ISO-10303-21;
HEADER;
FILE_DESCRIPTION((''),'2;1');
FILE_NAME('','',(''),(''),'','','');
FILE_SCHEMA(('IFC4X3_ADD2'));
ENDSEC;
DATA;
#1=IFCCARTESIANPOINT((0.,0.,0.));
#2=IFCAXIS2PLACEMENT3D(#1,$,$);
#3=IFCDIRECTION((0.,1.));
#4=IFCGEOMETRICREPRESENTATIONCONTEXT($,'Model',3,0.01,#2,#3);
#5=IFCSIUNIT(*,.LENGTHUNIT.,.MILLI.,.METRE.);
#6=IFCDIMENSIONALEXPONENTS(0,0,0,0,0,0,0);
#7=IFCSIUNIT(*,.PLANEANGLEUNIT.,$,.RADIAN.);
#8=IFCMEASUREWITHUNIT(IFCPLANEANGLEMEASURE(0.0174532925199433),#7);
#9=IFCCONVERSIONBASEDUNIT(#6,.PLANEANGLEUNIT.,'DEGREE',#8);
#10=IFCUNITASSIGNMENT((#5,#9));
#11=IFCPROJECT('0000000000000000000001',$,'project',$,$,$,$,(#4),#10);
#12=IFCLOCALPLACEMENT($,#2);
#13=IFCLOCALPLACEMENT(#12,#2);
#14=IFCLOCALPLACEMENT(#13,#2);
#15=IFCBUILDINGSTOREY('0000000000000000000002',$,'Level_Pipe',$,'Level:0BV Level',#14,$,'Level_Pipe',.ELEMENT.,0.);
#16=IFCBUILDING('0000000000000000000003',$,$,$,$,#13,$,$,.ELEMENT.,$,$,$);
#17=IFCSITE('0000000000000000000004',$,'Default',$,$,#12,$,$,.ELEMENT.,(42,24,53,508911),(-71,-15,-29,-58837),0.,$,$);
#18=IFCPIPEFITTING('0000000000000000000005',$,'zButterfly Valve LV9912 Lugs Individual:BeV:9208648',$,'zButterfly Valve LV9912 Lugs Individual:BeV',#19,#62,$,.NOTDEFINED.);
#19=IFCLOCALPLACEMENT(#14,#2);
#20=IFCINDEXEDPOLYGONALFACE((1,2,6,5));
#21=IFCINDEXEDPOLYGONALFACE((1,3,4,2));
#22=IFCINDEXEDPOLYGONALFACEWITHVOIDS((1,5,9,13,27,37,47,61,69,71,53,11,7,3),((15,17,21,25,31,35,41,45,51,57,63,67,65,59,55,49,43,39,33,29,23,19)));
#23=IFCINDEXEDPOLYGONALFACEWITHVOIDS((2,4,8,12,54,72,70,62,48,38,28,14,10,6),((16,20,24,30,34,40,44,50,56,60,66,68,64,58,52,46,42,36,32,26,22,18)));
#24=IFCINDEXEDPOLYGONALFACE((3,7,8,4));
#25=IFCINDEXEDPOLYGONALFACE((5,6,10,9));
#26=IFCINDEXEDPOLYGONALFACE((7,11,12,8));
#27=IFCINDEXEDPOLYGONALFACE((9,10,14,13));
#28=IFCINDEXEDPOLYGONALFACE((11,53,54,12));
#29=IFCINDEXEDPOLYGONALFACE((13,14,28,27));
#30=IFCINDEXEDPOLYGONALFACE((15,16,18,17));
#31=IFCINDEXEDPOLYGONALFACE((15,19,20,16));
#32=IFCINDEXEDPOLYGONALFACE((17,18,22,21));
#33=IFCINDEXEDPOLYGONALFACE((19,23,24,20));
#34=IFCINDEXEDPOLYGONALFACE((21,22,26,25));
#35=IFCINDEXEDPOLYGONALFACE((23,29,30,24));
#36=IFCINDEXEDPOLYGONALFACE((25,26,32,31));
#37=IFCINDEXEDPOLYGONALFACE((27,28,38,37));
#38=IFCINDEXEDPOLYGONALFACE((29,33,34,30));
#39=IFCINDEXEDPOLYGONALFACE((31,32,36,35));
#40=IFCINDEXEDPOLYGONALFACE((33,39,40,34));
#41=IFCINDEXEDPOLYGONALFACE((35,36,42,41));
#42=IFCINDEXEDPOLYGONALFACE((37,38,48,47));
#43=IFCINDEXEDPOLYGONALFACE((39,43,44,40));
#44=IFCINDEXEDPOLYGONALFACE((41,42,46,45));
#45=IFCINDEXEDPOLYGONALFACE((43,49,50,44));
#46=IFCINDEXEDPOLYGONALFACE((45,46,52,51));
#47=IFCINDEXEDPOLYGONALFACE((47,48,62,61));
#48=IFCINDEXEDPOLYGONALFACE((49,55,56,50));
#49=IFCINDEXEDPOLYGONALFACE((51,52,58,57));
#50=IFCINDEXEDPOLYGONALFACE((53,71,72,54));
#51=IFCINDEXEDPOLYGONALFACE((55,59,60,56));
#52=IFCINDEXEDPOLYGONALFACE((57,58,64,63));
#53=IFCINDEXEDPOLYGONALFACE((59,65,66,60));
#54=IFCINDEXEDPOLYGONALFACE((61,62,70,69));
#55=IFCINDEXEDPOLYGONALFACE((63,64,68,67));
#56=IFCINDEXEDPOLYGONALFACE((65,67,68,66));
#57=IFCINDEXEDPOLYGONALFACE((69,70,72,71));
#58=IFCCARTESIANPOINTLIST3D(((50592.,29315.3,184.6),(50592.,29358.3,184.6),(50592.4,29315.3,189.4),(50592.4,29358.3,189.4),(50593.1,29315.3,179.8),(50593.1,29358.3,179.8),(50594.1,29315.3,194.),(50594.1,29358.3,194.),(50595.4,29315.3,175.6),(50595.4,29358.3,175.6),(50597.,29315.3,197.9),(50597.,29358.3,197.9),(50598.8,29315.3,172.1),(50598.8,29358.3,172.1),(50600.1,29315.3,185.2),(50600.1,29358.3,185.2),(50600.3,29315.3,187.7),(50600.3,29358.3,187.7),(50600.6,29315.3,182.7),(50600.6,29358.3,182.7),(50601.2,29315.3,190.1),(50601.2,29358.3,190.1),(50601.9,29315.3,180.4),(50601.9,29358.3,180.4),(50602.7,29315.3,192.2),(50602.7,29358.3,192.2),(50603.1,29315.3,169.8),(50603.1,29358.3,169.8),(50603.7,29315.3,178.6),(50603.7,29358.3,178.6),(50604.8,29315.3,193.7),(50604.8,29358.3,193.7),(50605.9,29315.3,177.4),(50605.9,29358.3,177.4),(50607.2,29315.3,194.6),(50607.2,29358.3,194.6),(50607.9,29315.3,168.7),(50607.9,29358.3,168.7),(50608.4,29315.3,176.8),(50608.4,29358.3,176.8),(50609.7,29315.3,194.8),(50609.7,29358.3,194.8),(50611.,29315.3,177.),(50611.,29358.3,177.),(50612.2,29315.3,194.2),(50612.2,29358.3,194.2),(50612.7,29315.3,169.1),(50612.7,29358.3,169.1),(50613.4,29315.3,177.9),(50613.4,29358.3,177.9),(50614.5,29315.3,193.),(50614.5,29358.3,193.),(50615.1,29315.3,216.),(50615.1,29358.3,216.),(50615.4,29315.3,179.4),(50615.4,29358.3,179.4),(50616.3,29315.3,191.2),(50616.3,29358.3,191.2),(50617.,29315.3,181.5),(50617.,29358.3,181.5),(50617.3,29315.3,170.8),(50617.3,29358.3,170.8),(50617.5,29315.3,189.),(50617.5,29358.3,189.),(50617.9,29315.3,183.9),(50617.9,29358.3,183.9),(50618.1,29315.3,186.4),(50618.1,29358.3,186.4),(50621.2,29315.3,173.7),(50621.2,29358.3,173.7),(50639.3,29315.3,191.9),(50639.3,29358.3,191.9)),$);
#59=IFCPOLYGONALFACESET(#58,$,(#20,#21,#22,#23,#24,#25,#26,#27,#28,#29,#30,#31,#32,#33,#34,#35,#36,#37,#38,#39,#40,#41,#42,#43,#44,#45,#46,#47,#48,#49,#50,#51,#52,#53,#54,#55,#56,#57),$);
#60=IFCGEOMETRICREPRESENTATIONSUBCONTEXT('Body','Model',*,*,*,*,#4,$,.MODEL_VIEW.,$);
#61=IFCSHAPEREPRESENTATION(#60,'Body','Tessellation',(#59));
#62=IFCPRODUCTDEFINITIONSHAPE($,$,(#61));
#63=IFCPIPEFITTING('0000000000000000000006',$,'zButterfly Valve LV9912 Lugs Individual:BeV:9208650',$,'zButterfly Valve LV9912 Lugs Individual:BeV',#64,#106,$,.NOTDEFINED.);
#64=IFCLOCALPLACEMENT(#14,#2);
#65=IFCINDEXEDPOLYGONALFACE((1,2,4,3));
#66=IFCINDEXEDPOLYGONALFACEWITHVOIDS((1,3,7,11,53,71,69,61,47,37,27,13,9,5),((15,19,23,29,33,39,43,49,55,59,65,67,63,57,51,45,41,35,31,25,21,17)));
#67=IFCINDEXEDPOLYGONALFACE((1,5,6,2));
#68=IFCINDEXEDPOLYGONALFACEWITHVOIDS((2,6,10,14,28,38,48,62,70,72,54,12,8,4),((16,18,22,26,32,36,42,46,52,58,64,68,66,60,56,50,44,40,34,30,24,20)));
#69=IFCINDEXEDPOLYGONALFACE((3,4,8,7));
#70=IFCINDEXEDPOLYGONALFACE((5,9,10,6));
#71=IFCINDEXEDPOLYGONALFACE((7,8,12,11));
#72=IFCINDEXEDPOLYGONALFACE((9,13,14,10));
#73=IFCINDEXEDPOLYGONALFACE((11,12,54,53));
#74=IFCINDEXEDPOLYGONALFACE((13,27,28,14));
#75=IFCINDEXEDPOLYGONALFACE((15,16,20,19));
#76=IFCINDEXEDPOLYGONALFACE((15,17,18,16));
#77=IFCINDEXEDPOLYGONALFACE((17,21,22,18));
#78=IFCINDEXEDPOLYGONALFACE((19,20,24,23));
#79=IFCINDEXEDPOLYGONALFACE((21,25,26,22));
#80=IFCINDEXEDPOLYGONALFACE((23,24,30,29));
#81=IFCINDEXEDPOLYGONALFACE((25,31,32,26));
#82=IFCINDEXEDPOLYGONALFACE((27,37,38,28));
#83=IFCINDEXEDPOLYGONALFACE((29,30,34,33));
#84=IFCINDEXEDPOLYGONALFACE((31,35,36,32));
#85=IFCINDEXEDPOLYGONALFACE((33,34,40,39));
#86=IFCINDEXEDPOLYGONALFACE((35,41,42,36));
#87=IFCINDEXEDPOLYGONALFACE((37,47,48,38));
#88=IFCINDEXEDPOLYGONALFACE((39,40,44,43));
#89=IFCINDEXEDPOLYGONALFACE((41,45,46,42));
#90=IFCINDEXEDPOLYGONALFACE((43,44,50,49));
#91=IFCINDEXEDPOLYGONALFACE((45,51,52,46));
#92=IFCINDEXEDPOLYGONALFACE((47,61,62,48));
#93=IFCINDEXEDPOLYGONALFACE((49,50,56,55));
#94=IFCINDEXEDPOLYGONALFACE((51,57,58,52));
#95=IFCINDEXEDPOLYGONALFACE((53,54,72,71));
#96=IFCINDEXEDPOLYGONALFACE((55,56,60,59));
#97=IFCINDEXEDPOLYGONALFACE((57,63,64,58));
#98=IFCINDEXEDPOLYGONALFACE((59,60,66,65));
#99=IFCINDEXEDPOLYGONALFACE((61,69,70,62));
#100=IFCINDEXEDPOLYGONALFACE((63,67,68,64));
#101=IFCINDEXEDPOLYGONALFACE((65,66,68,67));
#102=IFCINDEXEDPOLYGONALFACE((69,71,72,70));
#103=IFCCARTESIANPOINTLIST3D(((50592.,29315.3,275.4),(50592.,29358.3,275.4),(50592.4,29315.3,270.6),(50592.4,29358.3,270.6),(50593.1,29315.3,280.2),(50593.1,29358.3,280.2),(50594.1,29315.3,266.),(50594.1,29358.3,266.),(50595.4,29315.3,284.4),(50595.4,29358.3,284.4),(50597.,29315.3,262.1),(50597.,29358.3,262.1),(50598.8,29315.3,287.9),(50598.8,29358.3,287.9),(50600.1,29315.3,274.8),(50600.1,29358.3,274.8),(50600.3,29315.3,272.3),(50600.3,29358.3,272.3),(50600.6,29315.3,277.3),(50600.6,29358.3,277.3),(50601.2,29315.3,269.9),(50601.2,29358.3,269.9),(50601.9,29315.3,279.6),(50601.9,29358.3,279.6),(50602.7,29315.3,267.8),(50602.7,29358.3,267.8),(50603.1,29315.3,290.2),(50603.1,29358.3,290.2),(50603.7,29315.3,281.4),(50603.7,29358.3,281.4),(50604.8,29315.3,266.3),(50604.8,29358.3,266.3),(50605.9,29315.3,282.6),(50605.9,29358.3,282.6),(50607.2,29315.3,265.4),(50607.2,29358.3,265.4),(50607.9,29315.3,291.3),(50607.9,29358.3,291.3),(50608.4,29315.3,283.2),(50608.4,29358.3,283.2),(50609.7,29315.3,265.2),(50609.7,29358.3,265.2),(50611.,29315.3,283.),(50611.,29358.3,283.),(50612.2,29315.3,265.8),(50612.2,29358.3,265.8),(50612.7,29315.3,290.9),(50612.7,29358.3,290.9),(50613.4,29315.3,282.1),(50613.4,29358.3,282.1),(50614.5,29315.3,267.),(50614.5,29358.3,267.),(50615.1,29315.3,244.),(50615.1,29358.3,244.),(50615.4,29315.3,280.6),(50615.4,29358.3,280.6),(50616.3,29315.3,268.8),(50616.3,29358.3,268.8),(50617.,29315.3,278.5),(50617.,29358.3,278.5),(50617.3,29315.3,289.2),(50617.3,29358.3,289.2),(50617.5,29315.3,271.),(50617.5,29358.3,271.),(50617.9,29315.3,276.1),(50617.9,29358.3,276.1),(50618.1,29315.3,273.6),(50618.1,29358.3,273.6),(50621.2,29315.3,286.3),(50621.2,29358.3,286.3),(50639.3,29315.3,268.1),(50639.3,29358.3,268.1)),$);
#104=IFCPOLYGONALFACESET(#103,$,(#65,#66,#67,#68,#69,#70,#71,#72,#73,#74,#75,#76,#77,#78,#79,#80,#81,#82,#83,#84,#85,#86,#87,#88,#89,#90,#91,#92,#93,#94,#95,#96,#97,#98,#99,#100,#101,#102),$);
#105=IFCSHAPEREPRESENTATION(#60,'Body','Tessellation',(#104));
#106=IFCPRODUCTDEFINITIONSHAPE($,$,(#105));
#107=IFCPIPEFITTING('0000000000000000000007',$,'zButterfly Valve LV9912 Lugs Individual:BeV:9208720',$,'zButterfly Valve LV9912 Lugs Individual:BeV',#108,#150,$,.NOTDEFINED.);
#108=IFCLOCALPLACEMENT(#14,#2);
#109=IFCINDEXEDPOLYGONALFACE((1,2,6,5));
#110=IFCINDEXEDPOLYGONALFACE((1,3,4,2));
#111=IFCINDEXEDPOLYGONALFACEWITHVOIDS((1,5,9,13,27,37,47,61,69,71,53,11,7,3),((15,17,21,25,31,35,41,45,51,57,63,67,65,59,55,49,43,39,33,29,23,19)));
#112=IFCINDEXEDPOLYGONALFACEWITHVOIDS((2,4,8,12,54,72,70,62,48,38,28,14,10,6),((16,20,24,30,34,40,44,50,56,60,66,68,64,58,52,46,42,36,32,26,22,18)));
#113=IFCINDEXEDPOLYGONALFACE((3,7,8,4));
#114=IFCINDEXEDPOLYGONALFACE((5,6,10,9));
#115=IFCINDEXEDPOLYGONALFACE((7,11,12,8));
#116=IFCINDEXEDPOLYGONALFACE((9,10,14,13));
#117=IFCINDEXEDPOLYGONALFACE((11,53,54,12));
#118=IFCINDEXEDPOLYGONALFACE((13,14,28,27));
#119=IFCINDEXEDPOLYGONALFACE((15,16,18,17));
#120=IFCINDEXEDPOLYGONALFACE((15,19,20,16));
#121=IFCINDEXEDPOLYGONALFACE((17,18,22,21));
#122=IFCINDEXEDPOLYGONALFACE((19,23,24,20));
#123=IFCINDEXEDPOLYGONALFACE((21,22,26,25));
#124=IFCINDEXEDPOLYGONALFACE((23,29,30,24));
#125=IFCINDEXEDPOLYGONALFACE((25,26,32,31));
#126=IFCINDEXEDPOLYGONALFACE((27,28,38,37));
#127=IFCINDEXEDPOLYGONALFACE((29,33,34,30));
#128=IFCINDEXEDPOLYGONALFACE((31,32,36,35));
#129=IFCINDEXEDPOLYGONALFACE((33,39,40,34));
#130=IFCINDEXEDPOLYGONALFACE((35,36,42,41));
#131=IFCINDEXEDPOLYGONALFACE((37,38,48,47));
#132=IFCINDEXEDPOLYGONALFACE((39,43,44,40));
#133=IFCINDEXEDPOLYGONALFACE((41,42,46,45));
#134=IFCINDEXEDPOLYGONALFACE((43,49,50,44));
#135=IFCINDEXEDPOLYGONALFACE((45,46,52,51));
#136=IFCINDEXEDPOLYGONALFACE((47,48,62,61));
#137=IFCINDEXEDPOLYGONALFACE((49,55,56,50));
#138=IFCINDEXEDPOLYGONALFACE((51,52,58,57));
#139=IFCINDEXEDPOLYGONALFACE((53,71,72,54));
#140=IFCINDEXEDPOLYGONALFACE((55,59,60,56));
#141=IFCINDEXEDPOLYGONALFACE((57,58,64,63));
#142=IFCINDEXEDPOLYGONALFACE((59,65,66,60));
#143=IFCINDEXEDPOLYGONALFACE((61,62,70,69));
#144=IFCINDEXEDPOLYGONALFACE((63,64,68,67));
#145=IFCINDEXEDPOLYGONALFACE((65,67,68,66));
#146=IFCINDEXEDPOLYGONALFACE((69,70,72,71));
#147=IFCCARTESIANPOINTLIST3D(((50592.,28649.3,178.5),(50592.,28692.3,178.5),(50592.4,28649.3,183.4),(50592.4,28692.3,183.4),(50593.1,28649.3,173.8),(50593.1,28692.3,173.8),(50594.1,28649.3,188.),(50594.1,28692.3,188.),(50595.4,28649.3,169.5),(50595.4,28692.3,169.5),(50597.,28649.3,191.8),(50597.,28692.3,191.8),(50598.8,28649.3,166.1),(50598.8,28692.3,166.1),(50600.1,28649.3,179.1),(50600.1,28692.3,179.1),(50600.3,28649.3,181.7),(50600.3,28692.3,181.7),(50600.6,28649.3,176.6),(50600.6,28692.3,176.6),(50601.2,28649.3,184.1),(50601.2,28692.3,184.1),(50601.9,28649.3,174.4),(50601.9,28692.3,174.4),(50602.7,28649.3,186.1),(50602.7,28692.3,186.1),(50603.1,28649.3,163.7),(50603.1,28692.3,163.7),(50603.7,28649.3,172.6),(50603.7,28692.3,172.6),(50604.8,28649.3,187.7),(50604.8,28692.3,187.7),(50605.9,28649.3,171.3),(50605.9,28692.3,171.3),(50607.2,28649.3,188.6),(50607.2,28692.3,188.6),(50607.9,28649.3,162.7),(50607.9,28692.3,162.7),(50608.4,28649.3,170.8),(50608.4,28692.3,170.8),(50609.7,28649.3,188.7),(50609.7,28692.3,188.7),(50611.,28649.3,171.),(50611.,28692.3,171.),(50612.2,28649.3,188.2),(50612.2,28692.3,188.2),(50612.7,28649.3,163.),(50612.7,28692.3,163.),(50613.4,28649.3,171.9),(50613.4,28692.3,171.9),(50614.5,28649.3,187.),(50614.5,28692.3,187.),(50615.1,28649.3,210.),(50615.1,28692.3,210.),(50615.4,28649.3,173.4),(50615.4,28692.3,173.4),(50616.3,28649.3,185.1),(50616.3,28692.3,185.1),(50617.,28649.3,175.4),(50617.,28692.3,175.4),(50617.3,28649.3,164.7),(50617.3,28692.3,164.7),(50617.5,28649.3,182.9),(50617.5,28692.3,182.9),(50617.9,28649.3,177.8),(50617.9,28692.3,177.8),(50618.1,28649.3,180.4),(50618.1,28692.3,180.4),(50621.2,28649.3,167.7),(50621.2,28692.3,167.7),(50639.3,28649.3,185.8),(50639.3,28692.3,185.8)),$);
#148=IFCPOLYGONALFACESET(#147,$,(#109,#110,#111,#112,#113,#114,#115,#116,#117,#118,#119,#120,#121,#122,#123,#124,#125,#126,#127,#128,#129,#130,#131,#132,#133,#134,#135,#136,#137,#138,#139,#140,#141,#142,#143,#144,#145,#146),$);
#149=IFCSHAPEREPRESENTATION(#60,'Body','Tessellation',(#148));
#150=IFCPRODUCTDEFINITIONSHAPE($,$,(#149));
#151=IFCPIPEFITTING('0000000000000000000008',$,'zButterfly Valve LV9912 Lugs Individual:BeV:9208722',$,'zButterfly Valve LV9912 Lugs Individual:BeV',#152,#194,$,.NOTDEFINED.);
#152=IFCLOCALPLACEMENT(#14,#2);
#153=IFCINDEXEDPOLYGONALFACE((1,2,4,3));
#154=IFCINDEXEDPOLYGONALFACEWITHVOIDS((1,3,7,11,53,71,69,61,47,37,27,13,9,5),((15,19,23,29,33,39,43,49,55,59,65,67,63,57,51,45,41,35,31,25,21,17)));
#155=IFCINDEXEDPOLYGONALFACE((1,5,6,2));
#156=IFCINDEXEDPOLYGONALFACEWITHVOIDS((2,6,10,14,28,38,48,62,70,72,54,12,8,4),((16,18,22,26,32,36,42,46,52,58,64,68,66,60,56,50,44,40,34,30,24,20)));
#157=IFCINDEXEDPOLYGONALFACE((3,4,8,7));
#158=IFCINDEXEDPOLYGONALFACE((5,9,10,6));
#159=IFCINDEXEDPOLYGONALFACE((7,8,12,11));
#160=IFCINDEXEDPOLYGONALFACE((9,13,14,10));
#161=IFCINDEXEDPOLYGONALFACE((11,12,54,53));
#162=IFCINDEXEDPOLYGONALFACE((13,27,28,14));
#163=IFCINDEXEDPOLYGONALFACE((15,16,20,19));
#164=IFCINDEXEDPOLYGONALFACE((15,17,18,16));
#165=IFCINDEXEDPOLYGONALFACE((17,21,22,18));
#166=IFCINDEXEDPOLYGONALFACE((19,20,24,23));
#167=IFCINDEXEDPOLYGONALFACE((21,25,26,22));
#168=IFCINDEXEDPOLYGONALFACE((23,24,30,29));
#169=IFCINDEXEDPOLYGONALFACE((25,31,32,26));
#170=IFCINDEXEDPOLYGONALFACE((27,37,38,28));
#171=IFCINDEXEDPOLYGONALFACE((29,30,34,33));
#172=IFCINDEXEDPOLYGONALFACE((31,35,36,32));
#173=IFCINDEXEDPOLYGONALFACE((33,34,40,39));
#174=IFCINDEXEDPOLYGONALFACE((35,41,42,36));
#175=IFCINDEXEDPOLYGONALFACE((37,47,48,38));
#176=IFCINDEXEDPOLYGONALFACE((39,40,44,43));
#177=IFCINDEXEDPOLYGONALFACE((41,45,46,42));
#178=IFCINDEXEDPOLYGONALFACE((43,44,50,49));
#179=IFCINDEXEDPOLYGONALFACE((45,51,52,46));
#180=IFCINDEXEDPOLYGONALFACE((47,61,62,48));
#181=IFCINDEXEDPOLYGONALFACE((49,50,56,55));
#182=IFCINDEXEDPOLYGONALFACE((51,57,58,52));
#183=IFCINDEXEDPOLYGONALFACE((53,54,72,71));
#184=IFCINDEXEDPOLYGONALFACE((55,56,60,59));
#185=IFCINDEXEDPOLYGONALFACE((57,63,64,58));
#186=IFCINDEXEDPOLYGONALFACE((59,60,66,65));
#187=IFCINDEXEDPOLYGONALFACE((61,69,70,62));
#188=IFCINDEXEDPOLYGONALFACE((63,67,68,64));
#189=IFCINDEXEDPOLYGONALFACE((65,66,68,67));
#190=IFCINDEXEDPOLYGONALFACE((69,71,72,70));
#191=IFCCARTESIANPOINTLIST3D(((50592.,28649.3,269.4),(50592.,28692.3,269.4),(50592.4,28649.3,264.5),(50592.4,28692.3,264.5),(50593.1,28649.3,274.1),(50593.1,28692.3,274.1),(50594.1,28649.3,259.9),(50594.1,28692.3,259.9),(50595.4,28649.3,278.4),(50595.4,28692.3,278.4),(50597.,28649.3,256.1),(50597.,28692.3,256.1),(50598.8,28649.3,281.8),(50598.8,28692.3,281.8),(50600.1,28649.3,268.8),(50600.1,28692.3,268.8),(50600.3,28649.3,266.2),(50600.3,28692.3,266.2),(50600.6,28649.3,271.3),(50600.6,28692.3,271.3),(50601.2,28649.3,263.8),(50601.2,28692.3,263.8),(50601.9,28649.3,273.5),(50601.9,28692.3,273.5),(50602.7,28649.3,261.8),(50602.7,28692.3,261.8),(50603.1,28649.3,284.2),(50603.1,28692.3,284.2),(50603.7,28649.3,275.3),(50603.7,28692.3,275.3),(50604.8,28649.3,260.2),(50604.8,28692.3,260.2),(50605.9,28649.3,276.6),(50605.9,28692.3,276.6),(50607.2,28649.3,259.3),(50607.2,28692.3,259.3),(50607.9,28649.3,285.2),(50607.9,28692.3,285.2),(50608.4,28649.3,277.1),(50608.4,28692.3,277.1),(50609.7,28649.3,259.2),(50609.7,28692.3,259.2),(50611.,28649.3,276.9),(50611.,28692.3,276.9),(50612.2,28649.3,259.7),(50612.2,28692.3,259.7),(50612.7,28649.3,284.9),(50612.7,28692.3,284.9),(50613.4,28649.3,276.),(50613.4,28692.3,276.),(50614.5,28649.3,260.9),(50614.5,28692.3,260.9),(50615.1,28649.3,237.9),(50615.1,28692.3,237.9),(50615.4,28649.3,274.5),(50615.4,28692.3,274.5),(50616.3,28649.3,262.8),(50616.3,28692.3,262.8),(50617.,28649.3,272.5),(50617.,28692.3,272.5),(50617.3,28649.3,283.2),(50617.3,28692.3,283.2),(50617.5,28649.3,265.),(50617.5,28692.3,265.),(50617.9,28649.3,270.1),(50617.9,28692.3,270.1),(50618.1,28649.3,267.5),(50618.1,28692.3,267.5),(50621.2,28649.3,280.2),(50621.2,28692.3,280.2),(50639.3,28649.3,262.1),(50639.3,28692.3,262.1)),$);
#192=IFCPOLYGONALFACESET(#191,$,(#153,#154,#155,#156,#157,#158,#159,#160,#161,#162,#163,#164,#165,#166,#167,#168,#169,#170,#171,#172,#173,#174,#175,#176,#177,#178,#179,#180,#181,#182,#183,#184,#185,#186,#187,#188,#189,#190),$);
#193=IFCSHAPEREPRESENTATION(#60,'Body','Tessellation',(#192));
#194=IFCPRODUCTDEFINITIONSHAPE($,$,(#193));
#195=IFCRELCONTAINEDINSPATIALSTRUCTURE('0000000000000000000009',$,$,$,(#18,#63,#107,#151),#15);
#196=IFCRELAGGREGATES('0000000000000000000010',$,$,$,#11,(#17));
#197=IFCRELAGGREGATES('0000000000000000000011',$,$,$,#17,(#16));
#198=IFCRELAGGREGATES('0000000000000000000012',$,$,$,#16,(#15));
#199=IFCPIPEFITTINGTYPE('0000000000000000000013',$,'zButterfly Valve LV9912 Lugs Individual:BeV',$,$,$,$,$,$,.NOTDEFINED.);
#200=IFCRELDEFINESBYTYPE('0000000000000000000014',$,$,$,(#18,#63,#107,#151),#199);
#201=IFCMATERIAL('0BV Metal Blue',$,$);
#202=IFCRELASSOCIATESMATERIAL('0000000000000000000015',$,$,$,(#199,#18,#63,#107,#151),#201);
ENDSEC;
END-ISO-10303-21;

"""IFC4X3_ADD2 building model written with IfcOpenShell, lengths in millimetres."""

from ifc_helpers import new_model, entity, si_unit, converted_unit, direction, frame, frame_2d, origin, place, context, subcontext, project, spatial, polyline, circle_curve, parameter, trimmed, segment, composite_curve, outline, extrude, source, transform, mapped, material, type_object, type_shapes, element, save


model = new_model("IFC4X3_ADD2")

# Units and contexts
model_context = context("Model", 3, precision=0.01, world=origin(), true_north=direction((0.0, 1.0)))
body_context = subcontext(model_context, "Body", "Model", "MODEL_VIEW")
ifc_project = project(units=[si_unit("LENGTHUNIT", "METRE", prefix="MILLI"), converted_unit("PLANEANGLEUNIT", "DEGREE", entity("IfcPlaneAngleMeasure", 0.0174532925199433), si_unit("PLANEANGLEUNIT", "RADIAN"), dimensions=[0, 0, 0, 0, 0, 0, 0])], contexts=[model_context])

# Site, building, storey
site_placement = place(None, origin())
site = spatial("IfcSite", under=ifc_project, at=site_placement, Name="Default", CompositionType="ELEMENT", RefLatitude=(42, 24, 53, 508911), RefLongitude=(-71, -15, -29, -58837), RefElevation=0.0)
building_placement = place(site_placement, origin())
building = spatial("IfcBuilding", under=site, at=building_placement, CompositionType="ELEMENT")
storey_placement = place(building_placement, origin())
storey = spatial("IfcBuildingStorey", under=building, at=storey_placement, Name="Level_Pipe", ObjectType="Level:0BV Level", LongName="Level_Pipe", CompositionType="ELEMENT", Elevation=0.0)

# Pipe fittings
ifc_material_1 = material(Name="0BV Metal Blue")
pipe_fitting_type_1 = type_object("IfcPipeFittingType", Name="zButterfly Valve LV9912 Lugs Individual:BeV", PredefinedType="NOTDEFINED", material=ifc_material_1)
shared_shape_1 = source(origin(), body_context, "Body", "SweptSolid", [
    extrude(outline(composite_curve([segment(polyline([(-17.1, -12.8), (17.1, -12.8)]), True, "CONTINUOUS"), segment(polyline([(17.1, -12.8), (17.1, 12.8)]), True, "CONTINUOUS"), segment(trimmed(circle_curve(frame_2d((0.0, 12.8), x_axis=(1.0, 0.0)), 17.1), [parameter(360.0)], [parameter(180.0)], True, "PARAMETER"), True, "CONTINUOUS"), segment(polyline([(-17.1, 12.8), (-17.1, -12.8)]), True, "CONTINUOUS")], self_intersect=False), holes=[composite_curve([segment(trimmed(circle_curve(frame_2d((0.0, 12.8), x_axis=(1.0, 0.0)), 9.0), [parameter(0.0)], [parameter(180.0)], True, "PARAMETER"), False, "CONTINUOUS"), segment(trimmed(circle_curve(frame_2d((0.0, 12.8), x_axis=(1.0, 0.0)), 9.0), [parameter(180.0)], [parameter(0.0)], True, "PARAMETER"), False, "CONTINUOUS")], self_intersect=False)]), frame((0.0, -12.8, -21.5)), (0.0, 0.0, 1.0), 43.0),
])
type_shapes(pipe_fitting_type_1, [shared_shape_1])
for number, where, z_axis, x_axis, name in (
    (1, (50609.1, 29336.8, 185.8), (0.0, 1.0, 0.0), (0.707107, 0.0, -0.707107), "zButterfly Valve LV9912 Lugs Individual:BeV:9208648"),
    (2, (50609.1, 29336.8, 274.2), (0.0, 1.0, 0.0), (-0.707107, 0.0, -0.707107), "zButterfly Valve LV9912 Lugs Individual:BeV:9208650"),
    (3, (50609.1, 28670.8, 179.8), (0.0, -1.0, 0.0), (-0.707107, 0.0, 0.707107), "zButterfly Valve LV9912 Lugs Individual:BeV:9208720"),
    (4, (50609.1, 28670.8, 268.1), (0.0, -1.0, 0.0), (0.707107, 0.0, 0.707107), "zButterfly Valve LV9912 Lugs Individual:BeV:9208722"),
):
    element("IfcPipeFitting", number, at=place(storey_placement, frame(where, z_axis=z_axis, x_axis=x_axis)), inside=storey, type_object=pipe_fitting_type_1, material=ifc_material_1, Name=name, ObjectType="zButterfly Valve LV9912 Lugs Individual:BeV", PredefinedType="NOTDEFINED", context=body_context, shape_type="MappedRepresentation", body=[
        mapped(shared_shape_1, transform((0.0, 0.0, 0.0), scale=1.0)),
    ])

save(model, "model.ifc")
